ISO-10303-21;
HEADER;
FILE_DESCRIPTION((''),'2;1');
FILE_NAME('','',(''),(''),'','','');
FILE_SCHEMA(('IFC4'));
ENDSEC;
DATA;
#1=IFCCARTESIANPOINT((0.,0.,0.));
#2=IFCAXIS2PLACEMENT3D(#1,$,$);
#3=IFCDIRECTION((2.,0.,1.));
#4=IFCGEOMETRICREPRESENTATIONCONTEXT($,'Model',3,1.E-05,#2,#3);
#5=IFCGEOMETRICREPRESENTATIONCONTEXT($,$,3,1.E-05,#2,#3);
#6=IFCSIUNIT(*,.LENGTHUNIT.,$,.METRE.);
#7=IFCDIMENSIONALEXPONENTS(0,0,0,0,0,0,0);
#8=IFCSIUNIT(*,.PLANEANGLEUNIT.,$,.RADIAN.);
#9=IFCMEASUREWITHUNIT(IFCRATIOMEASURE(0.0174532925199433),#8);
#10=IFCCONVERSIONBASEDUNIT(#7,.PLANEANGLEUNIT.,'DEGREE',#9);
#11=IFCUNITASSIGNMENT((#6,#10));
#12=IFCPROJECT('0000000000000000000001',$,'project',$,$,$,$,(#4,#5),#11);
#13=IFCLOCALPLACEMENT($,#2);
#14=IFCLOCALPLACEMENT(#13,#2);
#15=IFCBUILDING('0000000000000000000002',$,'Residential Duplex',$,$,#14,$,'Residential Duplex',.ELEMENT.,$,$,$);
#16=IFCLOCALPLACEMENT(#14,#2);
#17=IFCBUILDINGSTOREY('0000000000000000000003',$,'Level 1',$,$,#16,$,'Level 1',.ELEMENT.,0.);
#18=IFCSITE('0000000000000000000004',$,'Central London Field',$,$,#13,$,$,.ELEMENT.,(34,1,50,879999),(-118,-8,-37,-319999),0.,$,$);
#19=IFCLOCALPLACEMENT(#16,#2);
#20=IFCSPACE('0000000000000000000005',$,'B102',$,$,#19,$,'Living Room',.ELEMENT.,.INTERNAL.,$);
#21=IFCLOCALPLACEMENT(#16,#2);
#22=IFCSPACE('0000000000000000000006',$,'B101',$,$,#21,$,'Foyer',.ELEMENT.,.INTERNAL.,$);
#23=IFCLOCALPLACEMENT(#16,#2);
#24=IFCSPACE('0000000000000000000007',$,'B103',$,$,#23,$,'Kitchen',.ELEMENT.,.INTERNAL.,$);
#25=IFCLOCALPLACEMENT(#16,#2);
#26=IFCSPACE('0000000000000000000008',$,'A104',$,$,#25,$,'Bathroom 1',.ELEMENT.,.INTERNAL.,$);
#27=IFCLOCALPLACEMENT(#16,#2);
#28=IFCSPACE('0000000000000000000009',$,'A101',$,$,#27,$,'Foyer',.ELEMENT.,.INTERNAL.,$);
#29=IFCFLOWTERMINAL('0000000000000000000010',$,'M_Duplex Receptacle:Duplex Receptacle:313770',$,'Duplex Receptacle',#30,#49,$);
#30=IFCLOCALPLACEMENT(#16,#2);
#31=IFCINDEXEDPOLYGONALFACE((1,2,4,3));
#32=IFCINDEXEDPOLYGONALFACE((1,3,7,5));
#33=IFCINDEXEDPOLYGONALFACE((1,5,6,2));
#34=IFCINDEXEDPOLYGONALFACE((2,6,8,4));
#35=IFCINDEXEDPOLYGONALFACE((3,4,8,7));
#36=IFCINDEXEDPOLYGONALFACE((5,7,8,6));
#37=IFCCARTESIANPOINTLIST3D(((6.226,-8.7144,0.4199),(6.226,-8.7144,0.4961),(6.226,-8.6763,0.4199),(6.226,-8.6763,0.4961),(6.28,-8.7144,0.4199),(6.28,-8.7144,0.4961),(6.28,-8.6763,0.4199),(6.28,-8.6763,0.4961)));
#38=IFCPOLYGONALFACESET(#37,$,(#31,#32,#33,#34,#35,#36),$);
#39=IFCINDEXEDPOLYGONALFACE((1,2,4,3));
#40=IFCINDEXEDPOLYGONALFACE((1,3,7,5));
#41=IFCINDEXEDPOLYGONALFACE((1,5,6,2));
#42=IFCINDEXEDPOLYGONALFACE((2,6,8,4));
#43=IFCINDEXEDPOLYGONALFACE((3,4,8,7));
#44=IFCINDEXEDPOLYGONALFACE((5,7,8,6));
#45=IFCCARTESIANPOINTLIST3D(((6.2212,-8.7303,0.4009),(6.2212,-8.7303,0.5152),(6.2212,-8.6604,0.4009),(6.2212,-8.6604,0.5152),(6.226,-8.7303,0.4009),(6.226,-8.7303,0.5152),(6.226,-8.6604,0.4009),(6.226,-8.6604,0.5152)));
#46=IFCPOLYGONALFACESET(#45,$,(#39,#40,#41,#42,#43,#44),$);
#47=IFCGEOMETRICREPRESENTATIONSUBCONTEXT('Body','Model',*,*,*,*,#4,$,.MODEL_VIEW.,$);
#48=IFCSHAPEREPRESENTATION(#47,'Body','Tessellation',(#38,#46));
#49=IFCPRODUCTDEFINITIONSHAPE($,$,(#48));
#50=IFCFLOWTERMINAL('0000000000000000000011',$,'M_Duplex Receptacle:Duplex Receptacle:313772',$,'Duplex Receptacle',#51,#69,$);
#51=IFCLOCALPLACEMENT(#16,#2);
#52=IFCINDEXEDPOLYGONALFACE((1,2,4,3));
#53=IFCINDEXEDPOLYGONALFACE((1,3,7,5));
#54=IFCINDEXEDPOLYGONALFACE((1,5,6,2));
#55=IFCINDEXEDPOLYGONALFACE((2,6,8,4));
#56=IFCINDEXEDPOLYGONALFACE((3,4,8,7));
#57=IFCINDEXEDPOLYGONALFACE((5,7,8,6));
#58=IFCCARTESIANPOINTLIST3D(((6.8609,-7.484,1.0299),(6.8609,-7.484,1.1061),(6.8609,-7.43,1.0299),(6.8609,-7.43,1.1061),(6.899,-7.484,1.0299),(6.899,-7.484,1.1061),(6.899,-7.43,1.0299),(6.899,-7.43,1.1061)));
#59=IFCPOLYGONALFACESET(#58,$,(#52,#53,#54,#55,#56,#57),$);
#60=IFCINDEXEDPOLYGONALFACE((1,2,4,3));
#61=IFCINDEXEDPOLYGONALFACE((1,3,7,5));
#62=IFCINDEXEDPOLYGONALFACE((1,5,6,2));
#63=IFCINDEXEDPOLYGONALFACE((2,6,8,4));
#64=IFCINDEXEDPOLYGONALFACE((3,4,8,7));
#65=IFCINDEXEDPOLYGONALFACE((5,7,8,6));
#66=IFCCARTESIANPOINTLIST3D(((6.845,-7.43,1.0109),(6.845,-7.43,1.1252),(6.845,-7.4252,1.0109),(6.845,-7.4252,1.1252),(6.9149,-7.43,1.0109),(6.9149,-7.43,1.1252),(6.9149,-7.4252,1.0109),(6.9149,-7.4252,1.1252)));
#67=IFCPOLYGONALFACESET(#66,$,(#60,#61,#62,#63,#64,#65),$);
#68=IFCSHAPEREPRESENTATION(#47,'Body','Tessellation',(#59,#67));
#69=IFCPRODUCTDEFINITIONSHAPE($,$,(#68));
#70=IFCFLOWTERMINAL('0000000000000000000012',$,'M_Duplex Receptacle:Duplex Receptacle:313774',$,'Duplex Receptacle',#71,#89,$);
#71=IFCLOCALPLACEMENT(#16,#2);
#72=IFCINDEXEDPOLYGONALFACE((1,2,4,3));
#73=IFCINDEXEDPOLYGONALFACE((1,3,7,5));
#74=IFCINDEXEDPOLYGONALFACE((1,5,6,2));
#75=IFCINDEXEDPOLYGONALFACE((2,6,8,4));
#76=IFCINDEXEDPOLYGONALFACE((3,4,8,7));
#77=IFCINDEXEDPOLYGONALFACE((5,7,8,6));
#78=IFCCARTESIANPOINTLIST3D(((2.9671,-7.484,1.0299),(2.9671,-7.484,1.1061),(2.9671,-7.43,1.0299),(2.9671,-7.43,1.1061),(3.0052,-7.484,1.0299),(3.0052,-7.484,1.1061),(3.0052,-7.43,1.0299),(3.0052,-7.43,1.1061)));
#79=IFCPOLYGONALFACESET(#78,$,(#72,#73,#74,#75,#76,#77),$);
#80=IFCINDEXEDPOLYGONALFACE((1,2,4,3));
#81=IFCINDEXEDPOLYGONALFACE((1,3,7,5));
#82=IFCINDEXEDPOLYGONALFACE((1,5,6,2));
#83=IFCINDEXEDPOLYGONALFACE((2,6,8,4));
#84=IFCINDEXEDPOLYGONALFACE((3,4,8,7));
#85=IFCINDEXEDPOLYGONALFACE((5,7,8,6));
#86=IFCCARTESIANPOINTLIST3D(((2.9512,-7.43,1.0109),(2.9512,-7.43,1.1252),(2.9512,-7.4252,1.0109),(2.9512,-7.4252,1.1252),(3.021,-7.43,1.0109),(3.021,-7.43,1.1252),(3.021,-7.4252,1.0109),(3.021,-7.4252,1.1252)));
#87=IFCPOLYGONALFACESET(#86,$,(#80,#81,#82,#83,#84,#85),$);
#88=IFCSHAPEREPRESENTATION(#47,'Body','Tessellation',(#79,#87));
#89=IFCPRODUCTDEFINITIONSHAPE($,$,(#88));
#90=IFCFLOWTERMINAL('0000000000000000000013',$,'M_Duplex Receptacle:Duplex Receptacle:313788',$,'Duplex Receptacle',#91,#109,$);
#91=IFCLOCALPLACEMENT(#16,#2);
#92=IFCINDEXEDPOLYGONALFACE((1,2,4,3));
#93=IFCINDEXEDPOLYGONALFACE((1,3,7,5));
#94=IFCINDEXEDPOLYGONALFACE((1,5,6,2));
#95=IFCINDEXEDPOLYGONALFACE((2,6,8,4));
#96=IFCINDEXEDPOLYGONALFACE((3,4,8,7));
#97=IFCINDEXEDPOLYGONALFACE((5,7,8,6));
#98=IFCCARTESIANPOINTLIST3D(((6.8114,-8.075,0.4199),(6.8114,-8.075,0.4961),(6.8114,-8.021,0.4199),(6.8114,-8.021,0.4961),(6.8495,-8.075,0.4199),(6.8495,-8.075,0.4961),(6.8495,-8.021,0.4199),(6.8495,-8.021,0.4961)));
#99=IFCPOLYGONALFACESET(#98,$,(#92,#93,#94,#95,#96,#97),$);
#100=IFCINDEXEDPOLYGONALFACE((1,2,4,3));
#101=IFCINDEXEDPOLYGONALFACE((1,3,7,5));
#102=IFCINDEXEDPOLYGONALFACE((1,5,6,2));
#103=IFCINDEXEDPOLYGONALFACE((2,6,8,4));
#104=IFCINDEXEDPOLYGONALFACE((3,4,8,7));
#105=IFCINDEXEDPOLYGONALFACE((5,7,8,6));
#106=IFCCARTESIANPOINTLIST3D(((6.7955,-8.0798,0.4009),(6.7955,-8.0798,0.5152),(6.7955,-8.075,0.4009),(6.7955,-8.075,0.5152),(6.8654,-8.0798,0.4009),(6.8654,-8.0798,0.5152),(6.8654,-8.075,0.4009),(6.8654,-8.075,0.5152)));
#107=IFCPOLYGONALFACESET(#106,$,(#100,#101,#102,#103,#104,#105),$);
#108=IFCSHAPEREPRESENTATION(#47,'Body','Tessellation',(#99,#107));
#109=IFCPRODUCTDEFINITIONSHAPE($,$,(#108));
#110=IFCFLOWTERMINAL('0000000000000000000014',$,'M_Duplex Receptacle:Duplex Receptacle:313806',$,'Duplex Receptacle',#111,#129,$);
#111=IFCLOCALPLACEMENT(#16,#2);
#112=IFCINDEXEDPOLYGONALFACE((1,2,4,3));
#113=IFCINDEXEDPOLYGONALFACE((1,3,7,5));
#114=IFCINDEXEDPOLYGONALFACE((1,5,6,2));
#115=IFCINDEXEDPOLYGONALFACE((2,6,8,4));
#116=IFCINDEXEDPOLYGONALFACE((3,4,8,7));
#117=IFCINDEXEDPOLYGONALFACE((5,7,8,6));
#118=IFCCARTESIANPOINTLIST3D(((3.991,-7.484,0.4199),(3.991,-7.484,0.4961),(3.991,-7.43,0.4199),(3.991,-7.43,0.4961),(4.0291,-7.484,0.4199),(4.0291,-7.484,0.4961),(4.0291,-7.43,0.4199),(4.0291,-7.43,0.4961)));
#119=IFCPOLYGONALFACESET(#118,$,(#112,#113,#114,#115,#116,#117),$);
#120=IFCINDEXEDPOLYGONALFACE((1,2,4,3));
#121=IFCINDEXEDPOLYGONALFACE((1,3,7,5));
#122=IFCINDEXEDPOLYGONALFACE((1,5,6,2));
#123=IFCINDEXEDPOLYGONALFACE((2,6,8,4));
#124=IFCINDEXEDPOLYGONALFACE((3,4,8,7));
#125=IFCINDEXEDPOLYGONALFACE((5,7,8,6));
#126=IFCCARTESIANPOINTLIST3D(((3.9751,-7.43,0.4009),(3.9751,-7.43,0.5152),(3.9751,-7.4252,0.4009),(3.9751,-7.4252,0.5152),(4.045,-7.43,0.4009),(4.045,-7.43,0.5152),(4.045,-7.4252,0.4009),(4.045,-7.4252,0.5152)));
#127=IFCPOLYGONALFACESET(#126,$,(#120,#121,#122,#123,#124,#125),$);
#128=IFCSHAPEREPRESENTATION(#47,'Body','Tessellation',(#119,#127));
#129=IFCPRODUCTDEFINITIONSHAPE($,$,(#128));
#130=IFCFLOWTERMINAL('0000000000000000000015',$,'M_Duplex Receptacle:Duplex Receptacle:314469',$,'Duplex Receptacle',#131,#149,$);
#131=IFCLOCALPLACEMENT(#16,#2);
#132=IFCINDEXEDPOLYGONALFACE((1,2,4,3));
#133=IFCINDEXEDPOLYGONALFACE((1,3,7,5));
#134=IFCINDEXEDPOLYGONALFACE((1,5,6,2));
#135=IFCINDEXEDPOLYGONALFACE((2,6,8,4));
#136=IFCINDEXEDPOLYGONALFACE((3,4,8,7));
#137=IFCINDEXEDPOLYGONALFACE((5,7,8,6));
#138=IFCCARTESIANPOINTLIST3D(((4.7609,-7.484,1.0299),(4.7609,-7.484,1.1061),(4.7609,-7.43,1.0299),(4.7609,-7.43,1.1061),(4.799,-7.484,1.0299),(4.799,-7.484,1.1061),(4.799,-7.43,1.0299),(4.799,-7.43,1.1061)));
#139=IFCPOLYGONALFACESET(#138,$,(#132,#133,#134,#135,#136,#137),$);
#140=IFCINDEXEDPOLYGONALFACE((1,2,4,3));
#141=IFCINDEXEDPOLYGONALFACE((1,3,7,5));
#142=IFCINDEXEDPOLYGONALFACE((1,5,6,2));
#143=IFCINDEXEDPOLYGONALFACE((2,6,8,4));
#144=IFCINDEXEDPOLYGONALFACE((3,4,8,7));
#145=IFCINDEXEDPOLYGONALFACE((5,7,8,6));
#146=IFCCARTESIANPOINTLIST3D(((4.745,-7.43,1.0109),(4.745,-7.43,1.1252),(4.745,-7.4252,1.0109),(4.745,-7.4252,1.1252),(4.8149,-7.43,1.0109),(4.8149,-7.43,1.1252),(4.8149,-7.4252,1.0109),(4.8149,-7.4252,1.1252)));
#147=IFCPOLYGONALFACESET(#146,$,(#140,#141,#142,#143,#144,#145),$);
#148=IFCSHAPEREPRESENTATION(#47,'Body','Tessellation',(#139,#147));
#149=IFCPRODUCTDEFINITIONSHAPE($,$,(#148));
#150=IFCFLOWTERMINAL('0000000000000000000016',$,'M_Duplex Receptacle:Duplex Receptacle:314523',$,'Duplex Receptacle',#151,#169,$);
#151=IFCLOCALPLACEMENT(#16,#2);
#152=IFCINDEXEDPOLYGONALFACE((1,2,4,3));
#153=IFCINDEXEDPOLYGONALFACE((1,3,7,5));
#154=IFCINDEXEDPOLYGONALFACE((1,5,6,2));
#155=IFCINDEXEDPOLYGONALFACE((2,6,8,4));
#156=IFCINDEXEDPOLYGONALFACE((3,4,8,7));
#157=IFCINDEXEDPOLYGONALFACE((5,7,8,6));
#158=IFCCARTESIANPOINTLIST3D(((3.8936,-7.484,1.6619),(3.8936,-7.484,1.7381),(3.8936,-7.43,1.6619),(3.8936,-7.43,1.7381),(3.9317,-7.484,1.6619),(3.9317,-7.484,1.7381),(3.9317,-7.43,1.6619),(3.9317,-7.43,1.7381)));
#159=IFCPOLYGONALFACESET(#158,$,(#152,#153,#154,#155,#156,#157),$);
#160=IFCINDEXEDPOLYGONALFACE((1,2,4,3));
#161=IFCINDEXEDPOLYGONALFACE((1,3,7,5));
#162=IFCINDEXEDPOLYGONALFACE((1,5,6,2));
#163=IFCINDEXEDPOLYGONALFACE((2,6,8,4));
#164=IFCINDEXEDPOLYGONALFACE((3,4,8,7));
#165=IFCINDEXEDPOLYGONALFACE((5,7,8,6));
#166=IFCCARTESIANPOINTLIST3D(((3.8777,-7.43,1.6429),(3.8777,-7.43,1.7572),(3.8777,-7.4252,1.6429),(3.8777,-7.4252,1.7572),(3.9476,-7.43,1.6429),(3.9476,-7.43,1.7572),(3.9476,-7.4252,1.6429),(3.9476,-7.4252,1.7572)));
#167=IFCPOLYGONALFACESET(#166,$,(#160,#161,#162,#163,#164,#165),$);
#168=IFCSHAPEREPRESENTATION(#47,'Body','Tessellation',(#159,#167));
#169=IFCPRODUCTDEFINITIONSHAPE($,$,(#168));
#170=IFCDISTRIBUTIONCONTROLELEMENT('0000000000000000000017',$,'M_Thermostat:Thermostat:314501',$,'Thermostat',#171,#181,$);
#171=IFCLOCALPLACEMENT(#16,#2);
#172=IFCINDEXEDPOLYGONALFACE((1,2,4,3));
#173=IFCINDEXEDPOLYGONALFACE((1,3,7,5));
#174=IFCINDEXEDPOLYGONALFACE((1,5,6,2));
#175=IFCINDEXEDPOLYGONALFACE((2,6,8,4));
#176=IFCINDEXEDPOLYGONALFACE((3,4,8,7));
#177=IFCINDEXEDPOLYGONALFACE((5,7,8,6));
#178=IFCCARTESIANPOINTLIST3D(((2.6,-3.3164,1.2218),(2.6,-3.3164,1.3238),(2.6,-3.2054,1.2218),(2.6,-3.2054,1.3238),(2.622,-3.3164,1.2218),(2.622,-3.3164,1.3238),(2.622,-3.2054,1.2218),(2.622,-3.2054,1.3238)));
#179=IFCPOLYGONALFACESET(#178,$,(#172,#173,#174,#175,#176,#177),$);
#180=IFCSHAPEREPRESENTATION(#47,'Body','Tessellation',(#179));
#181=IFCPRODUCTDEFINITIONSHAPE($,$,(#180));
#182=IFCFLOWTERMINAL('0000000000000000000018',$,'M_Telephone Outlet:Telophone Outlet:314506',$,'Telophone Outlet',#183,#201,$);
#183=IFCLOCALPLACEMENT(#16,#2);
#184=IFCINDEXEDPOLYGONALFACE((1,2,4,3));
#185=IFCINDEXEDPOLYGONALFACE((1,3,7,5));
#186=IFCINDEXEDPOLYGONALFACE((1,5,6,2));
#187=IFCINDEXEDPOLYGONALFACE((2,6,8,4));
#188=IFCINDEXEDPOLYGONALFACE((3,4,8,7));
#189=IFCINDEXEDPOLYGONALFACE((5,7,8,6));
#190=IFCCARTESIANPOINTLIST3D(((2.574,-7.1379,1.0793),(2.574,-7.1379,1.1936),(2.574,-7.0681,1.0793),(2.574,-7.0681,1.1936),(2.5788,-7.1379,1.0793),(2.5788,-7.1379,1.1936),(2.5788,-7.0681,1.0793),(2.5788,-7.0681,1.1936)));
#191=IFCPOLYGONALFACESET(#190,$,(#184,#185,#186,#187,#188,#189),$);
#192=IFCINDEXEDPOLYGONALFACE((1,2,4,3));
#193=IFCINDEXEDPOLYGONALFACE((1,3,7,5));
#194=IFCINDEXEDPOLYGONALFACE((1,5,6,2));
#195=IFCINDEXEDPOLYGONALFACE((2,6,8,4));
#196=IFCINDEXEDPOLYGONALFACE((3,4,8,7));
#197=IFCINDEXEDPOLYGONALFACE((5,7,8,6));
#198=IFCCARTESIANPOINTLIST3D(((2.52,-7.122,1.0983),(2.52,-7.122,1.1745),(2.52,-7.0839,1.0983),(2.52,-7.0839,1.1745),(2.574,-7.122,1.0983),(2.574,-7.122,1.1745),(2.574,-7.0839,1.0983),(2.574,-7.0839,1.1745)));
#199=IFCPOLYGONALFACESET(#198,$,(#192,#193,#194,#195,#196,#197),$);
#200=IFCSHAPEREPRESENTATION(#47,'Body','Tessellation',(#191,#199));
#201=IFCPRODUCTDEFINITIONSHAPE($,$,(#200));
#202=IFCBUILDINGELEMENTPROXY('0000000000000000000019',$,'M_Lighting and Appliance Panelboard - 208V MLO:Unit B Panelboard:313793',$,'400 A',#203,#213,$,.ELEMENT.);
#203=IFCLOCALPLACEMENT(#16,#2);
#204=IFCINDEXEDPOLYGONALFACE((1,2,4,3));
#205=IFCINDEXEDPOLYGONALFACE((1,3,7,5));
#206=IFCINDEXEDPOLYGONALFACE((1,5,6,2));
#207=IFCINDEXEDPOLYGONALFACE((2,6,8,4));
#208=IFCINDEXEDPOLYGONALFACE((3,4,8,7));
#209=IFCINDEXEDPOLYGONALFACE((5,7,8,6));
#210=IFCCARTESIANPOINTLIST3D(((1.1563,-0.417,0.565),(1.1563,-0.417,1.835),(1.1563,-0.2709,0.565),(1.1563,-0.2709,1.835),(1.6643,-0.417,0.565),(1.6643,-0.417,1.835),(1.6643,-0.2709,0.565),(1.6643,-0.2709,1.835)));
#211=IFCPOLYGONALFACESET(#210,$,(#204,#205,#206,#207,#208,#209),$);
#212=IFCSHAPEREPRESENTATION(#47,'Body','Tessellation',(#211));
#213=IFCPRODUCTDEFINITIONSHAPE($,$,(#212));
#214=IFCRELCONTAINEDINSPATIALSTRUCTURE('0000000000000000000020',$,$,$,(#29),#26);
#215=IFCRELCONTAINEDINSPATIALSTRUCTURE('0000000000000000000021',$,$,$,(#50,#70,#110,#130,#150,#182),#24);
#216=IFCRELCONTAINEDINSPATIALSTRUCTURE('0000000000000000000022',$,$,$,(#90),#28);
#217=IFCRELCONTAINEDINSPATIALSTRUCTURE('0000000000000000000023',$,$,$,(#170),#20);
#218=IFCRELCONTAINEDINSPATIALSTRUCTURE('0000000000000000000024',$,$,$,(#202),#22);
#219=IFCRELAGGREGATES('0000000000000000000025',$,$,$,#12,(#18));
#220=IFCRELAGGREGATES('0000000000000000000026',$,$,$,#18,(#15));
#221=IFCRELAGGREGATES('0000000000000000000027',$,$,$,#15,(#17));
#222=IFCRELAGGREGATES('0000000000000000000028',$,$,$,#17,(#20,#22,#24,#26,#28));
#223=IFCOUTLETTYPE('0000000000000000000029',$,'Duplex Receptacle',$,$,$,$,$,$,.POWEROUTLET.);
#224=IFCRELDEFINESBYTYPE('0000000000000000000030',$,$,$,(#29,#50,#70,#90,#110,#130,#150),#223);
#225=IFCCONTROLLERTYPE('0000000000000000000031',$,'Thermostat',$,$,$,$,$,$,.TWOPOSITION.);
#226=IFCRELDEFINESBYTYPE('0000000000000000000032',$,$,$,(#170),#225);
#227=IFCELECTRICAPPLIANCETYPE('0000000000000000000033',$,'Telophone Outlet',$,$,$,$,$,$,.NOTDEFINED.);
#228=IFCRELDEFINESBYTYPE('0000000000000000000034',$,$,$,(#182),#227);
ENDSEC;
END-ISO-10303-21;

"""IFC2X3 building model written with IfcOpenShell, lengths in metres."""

from ifc_helpers import new_model, entity, si_unit, converted_unit, direction, frame, frame_2d, origin, origin_2d_with_axis, place, context, subcontext, project, spatial, rectangle, extrude, source, transform, mapped, type_object, type_shapes, element, save


model = new_model("IFC2X3")

# Units and contexts
model_context = context("Model", 3, precision=1e-05, world=origin(), true_north=direction((2.0, 0.0, 1.0)))
context_of_model = context(None, 3, precision=1e-05, world=origin(), true_north=direction((2.0, 0.0, 1.0)))
body_context = subcontext(model_context, "Body", "Model", "MODEL_VIEW")
ifc_project = project(units=[si_unit("LENGTHUNIT", "METRE"), converted_unit("PLANEANGLEUNIT", "DEGREE", entity("IfcRatioMeasure", 0.0174532925199433), si_unit("PLANEANGLEUNIT", "RADIAN"), dimensions=[0, 0, 0, 0, 0, 0, 0])], contexts=[model_context, context_of_model])

# Site, building, storey
site_placement = place(None, origin())
site = spatial("IfcSite", under=ifc_project, at=site_placement, Name="Central London Field", CompositionType="ELEMENT", RefLatitude=(34, 1, 50, 879999), RefLongitude=(-118, -8, -37, -319999), RefElevation=0.0)
building_placement = place(site_placement, origin())
building = spatial("IfcBuilding", under=site, at=building_placement, Name="Residential Duplex", LongName="Residential Duplex", CompositionType="ELEMENT")
storey_placement = place(building_placement, origin())
storey = spatial("IfcBuildingStorey", under=building, at=storey_placement, Name="Level 1", LongName="Level 1", CompositionType="ELEMENT", Elevation=0.0)

# Shared definitions
space_1_placement = place(storey_placement, origin())
space_1 = spatial("IfcSpace", under=storey, at=space_1_placement, Name="B102", LongName="Living Room", CompositionType="ELEMENT", InteriorOrExteriorSpace="INTERNAL")

# Shared definitions
space_2_placement = place(storey_placement, origin())
space_2 = spatial("IfcSpace", under=storey, at=space_2_placement, Name="B101", LongName="Foyer", CompositionType="ELEMENT", InteriorOrExteriorSpace="INTERNAL")

# Shared definitions
space_3_placement = place(storey_placement, origin())
space_3 = spatial("IfcSpace", under=storey, at=space_3_placement, Name="B103", LongName="Kitchen", CompositionType="ELEMENT", InteriorOrExteriorSpace="INTERNAL")

# Shared definitions
outlet_type = type_object("IfcOutletType", Name="Duplex Receptacle", PredefinedType="POWEROUTLET")
shared_shape_1 = source(origin(), body_context, "Body", "SweptSolid", [
    extrude(rectangle(XDim=0.0381, YDim=0.0762, at=origin_2d_with_axis()), frame((0.0, 0.0, -0.054), z_axis=(0.0, 0.0, 1.0), x_axis=(-1.0, 0.0, 0.0)), (0.0, 0.0, 1.0), 0.054),
    extrude(rectangle(XDim=0.0698, YDim=0.1143, at=frame_2d((0.0, 0.0), x_axis=(1.0, 0.0))), frame((0.0, 0.0, 0.0), z_axis=(0.0, 0.0, 1.0), x_axis=(-1.0, 0.0, 0.0)), (0.0, 0.0, 1.0), 0.0048),
])
type_shapes(outlet_type, [shared_shape_1])

# Shared definitions
space_4_placement = place(storey_placement, origin())
space_4 = spatial("IfcSpace", under=storey, at=space_4_placement, Name="A104", LongName="Bathroom 1", CompositionType="ELEMENT", InteriorOrExteriorSpace="INTERNAL")

# Flow terminals
flow_terminal_1_placement = place(space_4_placement, frame((6.226, -8.6953, 0.458), z_axis=(-1.0, 0.0, 0.0), x_axis=(0.0, -1.0, 0.0)))
element("IfcFlowTerminal", 1, at=flow_terminal_1_placement, inside=space_4, type_object=outlet_type, Name="M_Duplex Receptacle:Duplex Receptacle:313770", ObjectType="Duplex Receptacle", context=body_context, shape_type="MappedRepresentation", body=[
    mapped(shared_shape_1, transform((0.0, 0.0, 0.0), scale=1.0)),
])
for number, where, z_axis, x_axis, name in (
    (2, (6.88, -7.43, 1.068), (0.0, 1.0, 0.0), (-1.0, 0.0, 0.0), "M_Duplex Receptacle:Duplex Receptacle:313772"),
    (3, (2.9861, -7.43, 1.068), (0.0, 1.0, 0.0), (-1.0, 0.0, 0.0), "M_Duplex Receptacle:Duplex Receptacle:313774"),
):
    element("IfcFlowTerminal", number, at=place(space_3_placement, frame(where, z_axis=z_axis, x_axis=x_axis)), inside=space_3, type_object=outlet_type, Name=name, ObjectType="Duplex Receptacle", context=body_context, shape_type="MappedRepresentation", body=[
        mapped(shared_shape_1, transform((0.0, 0.0, 0.0), scale=1.0)),
    ])

# Shared definitions
space_5_placement = place(storey_placement, origin())
space_5 = spatial("IfcSpace", under=storey, at=space_5_placement, Name="A101", LongName="Foyer", CompositionType="ELEMENT", InteriorOrExteriorSpace="INTERNAL")

# Flow terminals
flow_terminal_2_placement = place(space_5_placement, frame((6.8305, -8.075, 0.458), z_axis=(0.0, -1.0, 0.0), x_axis=(1.0, 0.0, 0.0)))
element("IfcFlowTerminal", 4, at=flow_terminal_2_placement, inside=space_5, type_object=outlet_type, Name="M_Duplex Receptacle:Duplex Receptacle:313788", ObjectType="Duplex Receptacle", context=body_context, shape_type="MappedRepresentation", body=[
    mapped(shared_shape_1, transform((0.0, 0.0, 0.0), scale=1.0)),
])
for number, where, z_axis, x_axis, name in (
    (5, (4.0101, -7.43, 0.458), (0.0, 1.0, 0.0), (-1.0, 0.0, 0.0), "M_Duplex Receptacle:Duplex Receptacle:313806"),
    (6, (4.78, -7.43, 1.068), (0.0, 1.0, 0.0), (-1.0, 0.0, 0.0), "M_Duplex Receptacle:Duplex Receptacle:314469"),
    (7, (3.9127, -7.43, 1.7), (0.0, 1.0, 0.0), (-1.0, 0.0, 0.0), "M_Duplex Receptacle:Duplex Receptacle:314523"),
):
    element("IfcFlowTerminal", number, at=place(space_3_placement, frame(where, z_axis=z_axis, x_axis=x_axis)), inside=space_3, type_object=outlet_type, Name=name, ObjectType="Duplex Receptacle", context=body_context, shape_type="MappedRepresentation", body=[
        mapped(shared_shape_1, transform((0.0, 0.0, 0.0), scale=1.0)),
    ])

# Distribution control element
controller_type = type_object("IfcControllerType", Name="Thermostat", PredefinedType="TWOPOSITION")
shared_shape_2 = source(origin(), body_context, "Body", "SweptSolid", [
    extrude(rectangle(XDim=0.102, YDim=0.111, at=origin_2d_with_axis()), frame((0.0, -0.051, 0.0), z_axis=(0.0, 0.0, 1.0), x_axis=(0.0, 1.0, 0.0)), (0.0, 0.0, 1.0), 0.022),
])
type_shapes(controller_type, [shared_shape_2])
distribution_control_element_placement = place(space_1_placement, frame((2.6, -3.2609, 1.3238), z_axis=(1.0, 0.0, 0.0), x_axis=(0.0, 1.0, 0.0)))
element("IfcDistributionControlElement", 8, at=distribution_control_element_placement, inside=space_1, type_object=controller_type, Name="M_Thermostat:Thermostat:314501", ObjectType="Thermostat", context=body_context, shape_type="MappedRepresentation", body=[
    mapped(shared_shape_2, transform((0.0, 0.0, 0.0), scale=1.0)),
])

# Flow terminal
electric_appliance_type = type_object("IfcElectricApplianceType", Name="Telophone Outlet", PredefinedType="NOTDEFINED")
shared_shape_3 = source(origin(), body_context, "Body", "SweptSolid", [
    extrude(rectangle(XDim=0.0699, YDim=0.1143, at=frame_2d((0.0, 0.0), x_axis=(1.0, 0.0))), frame((0.0, 0.0, 0.0), z_axis=(0.0, 0.0, 1.0), x_axis=(-1.0, 0.0, 0.0)), (0.0, 0.0, 1.0), 0.0048),
    extrude(rectangle(XDim=0.0381, YDim=0.0762, at=origin_2d_with_axis()), frame((0.0, 0.0, -0.054), z_axis=(0.0, 0.0, 1.0), x_axis=(-1.0, 0.0, 0.0)), (0.0, 0.0, 1.0), 0.054),
])
type_shapes(electric_appliance_type, [shared_shape_3])
flow_terminal_3_placement = place(space_3_placement, frame((2.574, -7.103, 1.1364), z_axis=(1.0, 0.0, 0.0), x_axis=(0.0, 1.0, 0.0)))
element("IfcFlowTerminal", 9, at=flow_terminal_3_placement, inside=space_3, type_object=electric_appliance_type, Name="M_Telephone Outlet:Telophone Outlet:314506", ObjectType="Telophone Outlet", context=body_context, shape_type="MappedRepresentation", body=[
    mapped(shared_shape_3, transform((0.0, 0.0, 0.0), scale=1.0)),
])

# Building element proxy
shared_shape_4 = source(origin(), body_context, "Body", "SweptSolid", [
    extrude(rectangle(XDim=0.508, YDim=1.27, at=origin_2d_with_axis()), frame((0.0, -0.4191, -0.1461), z_axis=(0.0, 0.0, 1.0), x_axis=(-1.0, 0.0, 0.0)), (0.0, 0.0, 1.0), 0.1461),
])
proxy_1_placement = place(space_2_placement, frame((1.4103, -0.417, 1.6191), z_axis=(0.0, -1.0, 0.0), x_axis=(1.0, 0.0, 0.0)))
element("IfcBuildingElementProxy", 10, at=proxy_1_placement, inside=space_2, Name="M_Lighting and Appliance Panelboard - 208V MLO:Unit B Panelboard:313793", ObjectType="400 A", CompositionType="ELEMENT", context=body_context, shape_type="MappedRepresentation", body=[
    mapped(shared_shape_4, transform((0.0, 0.0, 0.0), scale=1.0)),
])

save(model, "model.ifc")
